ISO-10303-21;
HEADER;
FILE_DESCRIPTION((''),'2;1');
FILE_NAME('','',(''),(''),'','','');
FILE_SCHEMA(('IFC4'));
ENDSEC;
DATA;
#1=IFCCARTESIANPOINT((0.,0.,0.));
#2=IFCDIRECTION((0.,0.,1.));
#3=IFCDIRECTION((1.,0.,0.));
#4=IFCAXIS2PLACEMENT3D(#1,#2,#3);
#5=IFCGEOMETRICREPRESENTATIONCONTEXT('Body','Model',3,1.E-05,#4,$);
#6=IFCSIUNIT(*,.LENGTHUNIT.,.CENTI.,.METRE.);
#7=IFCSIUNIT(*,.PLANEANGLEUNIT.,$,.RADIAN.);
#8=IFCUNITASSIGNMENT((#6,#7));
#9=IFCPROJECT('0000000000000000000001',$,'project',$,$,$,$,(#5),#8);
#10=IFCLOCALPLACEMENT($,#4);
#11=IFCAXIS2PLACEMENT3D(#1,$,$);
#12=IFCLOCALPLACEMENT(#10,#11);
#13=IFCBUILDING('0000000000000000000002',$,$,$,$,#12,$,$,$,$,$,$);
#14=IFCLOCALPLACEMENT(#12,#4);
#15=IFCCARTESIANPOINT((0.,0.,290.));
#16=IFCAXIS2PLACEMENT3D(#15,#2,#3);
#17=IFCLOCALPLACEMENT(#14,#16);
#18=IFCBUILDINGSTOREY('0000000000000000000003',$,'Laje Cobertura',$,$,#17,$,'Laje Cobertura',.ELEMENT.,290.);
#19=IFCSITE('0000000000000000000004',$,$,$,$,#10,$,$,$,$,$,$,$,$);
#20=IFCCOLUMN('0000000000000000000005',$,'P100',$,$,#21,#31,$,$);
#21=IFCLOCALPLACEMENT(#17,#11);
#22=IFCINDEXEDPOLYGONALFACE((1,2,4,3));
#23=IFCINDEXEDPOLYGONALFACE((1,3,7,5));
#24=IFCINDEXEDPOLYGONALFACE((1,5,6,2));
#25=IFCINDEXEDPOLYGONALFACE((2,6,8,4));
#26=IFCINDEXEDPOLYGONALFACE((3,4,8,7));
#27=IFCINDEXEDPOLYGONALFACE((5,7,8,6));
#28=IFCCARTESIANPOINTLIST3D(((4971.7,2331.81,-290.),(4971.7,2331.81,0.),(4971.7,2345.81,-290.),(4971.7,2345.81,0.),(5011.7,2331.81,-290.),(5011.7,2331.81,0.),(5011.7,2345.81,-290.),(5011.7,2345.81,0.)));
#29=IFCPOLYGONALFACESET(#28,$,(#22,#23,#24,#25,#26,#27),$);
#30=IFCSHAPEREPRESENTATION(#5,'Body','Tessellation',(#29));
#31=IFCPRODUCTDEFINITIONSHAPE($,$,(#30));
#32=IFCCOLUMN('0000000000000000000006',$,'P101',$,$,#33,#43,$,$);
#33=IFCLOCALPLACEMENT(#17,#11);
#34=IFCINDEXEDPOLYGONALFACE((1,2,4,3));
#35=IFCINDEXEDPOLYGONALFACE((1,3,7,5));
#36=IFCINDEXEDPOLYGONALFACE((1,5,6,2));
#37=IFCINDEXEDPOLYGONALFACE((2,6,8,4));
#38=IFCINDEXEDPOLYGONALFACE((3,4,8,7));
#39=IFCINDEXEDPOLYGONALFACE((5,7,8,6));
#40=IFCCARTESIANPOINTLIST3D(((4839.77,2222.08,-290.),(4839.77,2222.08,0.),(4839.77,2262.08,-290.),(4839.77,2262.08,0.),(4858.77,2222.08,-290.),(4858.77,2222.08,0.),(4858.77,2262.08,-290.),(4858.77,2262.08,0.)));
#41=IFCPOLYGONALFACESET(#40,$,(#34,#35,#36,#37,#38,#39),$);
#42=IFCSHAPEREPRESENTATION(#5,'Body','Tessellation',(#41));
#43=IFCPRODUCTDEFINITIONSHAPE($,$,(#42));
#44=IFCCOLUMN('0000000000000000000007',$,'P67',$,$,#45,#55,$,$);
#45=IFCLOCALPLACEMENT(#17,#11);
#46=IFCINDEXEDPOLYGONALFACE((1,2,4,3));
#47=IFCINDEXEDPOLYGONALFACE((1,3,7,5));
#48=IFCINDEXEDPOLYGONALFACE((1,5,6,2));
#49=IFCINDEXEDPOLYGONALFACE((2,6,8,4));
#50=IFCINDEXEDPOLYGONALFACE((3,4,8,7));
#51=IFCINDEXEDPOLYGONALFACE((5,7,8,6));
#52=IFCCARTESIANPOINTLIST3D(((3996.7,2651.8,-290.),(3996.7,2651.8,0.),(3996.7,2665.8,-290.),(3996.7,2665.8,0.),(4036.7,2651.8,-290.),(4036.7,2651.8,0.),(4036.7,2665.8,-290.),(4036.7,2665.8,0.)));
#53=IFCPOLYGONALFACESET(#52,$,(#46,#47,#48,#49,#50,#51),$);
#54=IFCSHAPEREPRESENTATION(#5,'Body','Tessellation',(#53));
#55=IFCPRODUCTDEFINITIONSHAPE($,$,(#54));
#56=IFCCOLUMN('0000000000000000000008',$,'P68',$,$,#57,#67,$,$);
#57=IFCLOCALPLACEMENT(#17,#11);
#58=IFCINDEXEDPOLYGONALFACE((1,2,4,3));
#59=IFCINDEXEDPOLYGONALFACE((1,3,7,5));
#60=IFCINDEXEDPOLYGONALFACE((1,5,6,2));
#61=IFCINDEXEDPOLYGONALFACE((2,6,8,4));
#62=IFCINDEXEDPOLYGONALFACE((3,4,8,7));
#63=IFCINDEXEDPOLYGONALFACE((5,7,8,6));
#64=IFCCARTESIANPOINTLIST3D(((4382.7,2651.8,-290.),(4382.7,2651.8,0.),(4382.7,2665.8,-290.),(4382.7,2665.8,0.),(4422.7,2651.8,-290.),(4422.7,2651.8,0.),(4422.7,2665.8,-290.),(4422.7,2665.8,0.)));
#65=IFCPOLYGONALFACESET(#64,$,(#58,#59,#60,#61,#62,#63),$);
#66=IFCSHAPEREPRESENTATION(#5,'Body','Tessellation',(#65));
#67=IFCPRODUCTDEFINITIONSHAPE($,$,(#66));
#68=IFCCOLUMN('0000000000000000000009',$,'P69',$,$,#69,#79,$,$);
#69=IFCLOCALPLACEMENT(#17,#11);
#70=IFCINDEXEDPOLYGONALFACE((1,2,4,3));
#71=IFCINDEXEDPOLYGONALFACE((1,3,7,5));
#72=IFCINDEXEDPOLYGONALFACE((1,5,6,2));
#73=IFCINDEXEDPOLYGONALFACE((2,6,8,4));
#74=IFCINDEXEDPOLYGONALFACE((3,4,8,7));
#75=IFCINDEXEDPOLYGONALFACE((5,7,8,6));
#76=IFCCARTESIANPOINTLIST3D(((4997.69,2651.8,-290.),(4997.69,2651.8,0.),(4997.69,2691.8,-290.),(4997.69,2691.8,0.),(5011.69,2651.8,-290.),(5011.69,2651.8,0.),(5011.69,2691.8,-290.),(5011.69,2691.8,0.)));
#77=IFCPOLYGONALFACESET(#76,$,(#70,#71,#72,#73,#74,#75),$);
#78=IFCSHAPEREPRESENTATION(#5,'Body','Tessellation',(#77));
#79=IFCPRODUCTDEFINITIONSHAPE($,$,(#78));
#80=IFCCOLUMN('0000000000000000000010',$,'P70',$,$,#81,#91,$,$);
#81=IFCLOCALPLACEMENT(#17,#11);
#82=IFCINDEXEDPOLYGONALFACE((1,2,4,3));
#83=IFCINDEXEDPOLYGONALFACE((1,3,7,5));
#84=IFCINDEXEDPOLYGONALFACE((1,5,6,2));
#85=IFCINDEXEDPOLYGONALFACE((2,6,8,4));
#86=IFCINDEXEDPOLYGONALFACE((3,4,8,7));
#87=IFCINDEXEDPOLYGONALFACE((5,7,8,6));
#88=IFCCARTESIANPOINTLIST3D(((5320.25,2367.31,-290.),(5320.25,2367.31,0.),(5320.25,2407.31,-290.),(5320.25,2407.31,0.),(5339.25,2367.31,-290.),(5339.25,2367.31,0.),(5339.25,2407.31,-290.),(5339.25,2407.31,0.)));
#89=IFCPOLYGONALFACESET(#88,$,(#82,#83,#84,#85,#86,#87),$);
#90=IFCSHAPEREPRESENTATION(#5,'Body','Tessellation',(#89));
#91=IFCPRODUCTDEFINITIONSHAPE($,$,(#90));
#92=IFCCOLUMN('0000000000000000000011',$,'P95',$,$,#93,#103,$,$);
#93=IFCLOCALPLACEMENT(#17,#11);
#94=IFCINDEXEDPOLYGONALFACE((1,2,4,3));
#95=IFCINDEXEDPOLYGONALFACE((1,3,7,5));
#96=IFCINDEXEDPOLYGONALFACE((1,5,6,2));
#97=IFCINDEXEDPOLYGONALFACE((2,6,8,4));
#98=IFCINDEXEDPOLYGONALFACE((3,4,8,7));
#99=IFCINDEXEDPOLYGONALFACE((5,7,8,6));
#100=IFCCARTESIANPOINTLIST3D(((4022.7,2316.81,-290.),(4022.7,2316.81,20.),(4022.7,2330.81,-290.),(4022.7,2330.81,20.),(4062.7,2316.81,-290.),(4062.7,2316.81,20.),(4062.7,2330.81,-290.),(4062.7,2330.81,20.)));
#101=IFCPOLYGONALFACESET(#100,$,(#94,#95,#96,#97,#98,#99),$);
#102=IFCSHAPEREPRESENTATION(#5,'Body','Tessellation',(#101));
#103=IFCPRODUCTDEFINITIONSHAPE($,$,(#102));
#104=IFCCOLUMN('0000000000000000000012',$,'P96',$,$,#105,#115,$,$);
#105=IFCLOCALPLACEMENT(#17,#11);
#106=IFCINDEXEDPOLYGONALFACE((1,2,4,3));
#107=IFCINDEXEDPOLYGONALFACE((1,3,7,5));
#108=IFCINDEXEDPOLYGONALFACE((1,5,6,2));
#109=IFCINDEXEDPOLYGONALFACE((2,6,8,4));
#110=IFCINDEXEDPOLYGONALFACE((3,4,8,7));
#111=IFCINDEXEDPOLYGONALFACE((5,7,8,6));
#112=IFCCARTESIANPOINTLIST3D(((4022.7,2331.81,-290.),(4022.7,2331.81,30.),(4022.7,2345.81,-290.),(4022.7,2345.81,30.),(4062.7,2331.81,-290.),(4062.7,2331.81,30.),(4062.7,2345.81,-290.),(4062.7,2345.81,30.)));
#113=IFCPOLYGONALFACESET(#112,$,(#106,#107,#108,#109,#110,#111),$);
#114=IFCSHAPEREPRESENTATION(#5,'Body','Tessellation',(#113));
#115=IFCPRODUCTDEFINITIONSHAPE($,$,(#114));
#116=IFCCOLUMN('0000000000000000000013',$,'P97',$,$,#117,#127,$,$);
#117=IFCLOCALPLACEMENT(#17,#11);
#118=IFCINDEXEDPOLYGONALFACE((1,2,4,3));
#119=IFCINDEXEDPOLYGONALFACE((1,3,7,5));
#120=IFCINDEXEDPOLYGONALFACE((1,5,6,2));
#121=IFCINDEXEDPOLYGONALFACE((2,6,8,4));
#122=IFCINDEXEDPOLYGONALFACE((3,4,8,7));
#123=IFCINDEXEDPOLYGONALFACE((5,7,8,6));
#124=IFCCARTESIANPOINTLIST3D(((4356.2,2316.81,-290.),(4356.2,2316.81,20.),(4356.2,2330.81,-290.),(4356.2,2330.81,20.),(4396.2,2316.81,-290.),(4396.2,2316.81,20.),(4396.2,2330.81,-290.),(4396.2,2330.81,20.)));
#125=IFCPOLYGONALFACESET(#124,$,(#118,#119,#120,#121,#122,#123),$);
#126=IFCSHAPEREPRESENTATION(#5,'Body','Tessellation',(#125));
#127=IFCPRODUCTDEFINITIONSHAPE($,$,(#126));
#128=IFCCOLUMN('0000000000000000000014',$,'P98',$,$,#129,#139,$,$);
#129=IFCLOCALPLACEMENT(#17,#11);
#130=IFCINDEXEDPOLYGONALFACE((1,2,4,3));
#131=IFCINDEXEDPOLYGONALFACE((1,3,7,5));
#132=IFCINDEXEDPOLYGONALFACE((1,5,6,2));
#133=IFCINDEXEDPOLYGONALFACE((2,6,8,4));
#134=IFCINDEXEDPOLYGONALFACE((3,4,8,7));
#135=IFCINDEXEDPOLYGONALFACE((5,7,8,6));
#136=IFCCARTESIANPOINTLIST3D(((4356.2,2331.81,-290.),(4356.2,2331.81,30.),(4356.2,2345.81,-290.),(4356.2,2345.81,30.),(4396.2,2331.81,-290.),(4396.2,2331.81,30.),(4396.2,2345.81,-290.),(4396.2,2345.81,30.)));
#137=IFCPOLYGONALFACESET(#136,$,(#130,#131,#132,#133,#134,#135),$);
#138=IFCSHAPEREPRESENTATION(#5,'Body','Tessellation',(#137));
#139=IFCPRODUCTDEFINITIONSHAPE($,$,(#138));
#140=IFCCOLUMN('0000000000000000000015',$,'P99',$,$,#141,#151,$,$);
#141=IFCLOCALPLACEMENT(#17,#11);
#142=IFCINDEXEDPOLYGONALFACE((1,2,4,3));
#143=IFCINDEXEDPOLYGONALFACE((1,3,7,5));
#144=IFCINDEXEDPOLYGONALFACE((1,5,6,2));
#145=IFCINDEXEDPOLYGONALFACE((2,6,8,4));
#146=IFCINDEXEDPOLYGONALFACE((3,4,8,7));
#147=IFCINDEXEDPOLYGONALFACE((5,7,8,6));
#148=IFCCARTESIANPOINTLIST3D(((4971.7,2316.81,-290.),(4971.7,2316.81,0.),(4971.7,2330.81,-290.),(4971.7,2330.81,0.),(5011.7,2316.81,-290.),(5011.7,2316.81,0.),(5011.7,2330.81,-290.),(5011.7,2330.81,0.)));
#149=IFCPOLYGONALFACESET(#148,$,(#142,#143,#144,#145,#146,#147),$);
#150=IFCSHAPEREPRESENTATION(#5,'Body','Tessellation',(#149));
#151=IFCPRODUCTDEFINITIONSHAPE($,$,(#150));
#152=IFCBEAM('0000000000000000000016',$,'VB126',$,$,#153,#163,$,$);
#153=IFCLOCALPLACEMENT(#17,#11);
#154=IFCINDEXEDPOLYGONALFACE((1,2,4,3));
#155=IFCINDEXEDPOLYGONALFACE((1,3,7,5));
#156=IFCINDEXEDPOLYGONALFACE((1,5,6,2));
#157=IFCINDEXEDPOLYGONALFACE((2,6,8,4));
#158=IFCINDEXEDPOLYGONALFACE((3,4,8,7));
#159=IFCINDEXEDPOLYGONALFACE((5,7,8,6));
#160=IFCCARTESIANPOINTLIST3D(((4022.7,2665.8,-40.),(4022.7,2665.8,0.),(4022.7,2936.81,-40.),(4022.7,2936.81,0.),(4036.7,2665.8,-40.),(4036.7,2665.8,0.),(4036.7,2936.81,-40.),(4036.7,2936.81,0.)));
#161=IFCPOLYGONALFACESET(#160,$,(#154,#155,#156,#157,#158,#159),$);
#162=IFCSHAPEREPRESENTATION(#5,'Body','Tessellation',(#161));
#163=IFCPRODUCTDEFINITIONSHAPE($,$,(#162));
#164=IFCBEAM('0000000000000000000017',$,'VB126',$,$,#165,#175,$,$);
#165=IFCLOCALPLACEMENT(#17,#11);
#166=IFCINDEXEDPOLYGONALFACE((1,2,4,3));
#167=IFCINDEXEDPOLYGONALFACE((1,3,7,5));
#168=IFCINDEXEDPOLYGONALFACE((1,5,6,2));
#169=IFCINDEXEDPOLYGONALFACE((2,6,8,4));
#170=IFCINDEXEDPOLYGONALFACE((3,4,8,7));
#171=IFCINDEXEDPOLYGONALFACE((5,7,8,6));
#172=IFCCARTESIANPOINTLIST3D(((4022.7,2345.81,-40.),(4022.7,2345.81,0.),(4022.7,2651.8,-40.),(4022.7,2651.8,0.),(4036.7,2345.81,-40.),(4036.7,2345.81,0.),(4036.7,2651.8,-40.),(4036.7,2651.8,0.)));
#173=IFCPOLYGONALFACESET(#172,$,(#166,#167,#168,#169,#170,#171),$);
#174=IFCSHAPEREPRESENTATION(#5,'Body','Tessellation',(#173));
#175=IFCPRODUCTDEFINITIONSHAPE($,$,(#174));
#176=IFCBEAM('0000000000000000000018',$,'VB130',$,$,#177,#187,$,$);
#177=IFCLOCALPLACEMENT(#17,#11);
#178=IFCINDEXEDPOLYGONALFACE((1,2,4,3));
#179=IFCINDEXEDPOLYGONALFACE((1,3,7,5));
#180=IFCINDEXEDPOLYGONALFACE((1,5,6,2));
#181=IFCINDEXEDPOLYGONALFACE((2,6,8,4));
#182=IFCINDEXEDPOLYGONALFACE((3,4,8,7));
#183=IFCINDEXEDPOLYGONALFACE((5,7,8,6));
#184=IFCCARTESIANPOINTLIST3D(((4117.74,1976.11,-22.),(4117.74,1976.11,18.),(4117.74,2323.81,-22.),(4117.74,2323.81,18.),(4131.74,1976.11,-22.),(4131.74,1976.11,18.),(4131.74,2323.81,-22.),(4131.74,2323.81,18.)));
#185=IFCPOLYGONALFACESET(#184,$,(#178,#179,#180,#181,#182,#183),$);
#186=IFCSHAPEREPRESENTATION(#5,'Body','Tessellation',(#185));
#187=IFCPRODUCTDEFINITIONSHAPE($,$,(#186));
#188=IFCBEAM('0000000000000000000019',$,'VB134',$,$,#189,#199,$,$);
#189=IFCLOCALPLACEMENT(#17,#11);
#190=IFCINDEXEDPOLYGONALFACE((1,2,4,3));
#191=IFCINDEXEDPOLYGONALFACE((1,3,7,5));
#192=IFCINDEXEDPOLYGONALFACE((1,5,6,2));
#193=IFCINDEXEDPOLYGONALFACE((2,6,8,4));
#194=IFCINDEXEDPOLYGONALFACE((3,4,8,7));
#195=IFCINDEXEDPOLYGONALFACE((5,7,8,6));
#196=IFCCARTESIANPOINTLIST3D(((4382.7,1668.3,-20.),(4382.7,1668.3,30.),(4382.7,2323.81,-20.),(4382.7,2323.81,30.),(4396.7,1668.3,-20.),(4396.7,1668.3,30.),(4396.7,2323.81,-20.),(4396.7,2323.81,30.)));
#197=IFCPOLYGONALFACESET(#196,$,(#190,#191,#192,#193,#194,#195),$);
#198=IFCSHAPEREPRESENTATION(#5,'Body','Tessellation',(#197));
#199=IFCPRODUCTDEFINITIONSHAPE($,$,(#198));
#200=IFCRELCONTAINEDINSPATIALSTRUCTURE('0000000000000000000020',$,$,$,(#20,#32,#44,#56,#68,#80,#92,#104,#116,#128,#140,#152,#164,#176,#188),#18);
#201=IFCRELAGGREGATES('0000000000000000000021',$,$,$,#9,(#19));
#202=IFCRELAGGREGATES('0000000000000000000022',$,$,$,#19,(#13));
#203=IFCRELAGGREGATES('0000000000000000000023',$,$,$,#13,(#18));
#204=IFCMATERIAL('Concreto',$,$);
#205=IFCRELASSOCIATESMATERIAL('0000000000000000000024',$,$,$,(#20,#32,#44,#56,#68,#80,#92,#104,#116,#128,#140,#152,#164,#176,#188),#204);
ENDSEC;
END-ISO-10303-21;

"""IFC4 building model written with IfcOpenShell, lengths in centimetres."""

from ifc_helpers import new_model, si_unit, frame, origin, origin_with_axes, origin_2d_with_axis, place, context, project, spatial, rectangle, extrude, material, element, save


model = new_model("IFC4")

# Units and contexts
model_context = context("Model", 3, precision=1e-05, world=origin_with_axes(), identifier="Body")
ifc_project = project(units=[si_unit("LENGTHUNIT", "METRE", prefix="CENTI"), si_unit("PLANEANGLEUNIT", "RADIAN")], contexts=[model_context])

# Site, building, storey
site_placement = place(None, origin_with_axes())
site = spatial("IfcSite", under=ifc_project, at=site_placement)
building_placement = place(site_placement, origin())
building = spatial("IfcBuilding", under=site, at=building_placement)
placement = place(building_placement, origin_with_axes())
storey_placement = place(placement, frame((0.0, 0.0, 290.0), z_axis=(0.0, 0.0, 1.0), x_axis=(1.0, 0.0, 0.0)))
storey = spatial("IfcBuildingStorey", under=building, at=storey_placement, Name="Laje Cobertura", LongName="Laje Cobertura", CompositionType="ELEMENT", Elevation=290.0)

# Columns
ifc_material = material(Name="Concreto")
column_1_placement = place(storey_placement, frame((4991.7, 2338.81, 0.0), z_axis=(0.0, 0.0, 1.0), x_axis=(1.0, 0.0, 0.0)))
element("IfcColumn", 1, at=column_1_placement, inside=storey, material=ifc_material, Name="P100", context=model_context, shape_type="SolidModel", body=[
    extrude(rectangle(XDim=14.0, YDim=40.0, at=origin_2d_with_axis()), frame((0.0, 0.0, 0.0), z_axis=(0.0, 0.0, 1.0), x_axis=(0.0, -1.0, 0.0)), (0.0, 0.0, -1.0), 290.0),
])
column_2_placement = place(storey_placement, frame((4849.27, 2242.08, 0.0), z_axis=(0.0, 0.0, 1.0), x_axis=(1.0, 0.0, 0.0)))
element("IfcColumn", 2, at=column_2_placement, inside=storey, material=ifc_material, Name="P101", context=model_context, shape_type="SolidModel", body=[
    extrude(rectangle(XDim=19.0, YDim=40.0, at=origin_2d_with_axis()), origin_with_axes(), (0.0, 0.0, -1.0), 290.0),
])
for number, where, z_axis, x_axis, name in (
    (3, (4016.7, 2658.8, 0.0), (0.0, 0.0, 1.0), (1.0, 0.0, 0.0), "P67"),
    (4, (4402.7, 2658.8, 0.0), (0.0, 0.0, 1.0), (1.0, 0.0, 0.0), "P68"),
):
    element("IfcColumn", number, at=place(storey_placement, frame(where, z_axis=z_axis, x_axis=x_axis)), inside=storey, material=ifc_material, Name=name, context=model_context, shape_type="SolidModel", body=[
        extrude(rectangle(XDim=14.0, YDim=40.0, at=origin_2d_with_axis()), frame((0.0, 0.0, 0.0), z_axis=(0.0, 0.0, 1.0), x_axis=(0.0, -1.0, 0.0)), (0.0, 0.0, -1.0), 290.0),
    ])
column_3_placement = place(storey_placement, frame((5004.69, 2671.8, 0.0), z_axis=(0.0, 0.0, 1.0), x_axis=(1.0, 0.0, 0.0)))
element("IfcColumn", 5, at=column_3_placement, inside=storey, material=ifc_material, Name="P69", context=model_context, shape_type="SolidModel", body=[
    extrude(rectangle(XDim=14.0, YDim=40.0, at=origin_2d_with_axis()), origin_with_axes(), (0.0, 0.0, -1.0), 290.0),
])
column_4_placement = place(storey_placement, frame((5329.75, 2387.31, 0.0), z_axis=(0.0, 0.0, 1.0), x_axis=(1.0, 0.0, 0.0)))
element("IfcColumn", 6, at=column_4_placement, inside=storey, material=ifc_material, Name="P70", context=model_context, shape_type="SolidModel", body=[
    extrude(rectangle(XDim=19.0, YDim=40.0, at=origin_2d_with_axis()), origin_with_axes(), (0.0, 0.0, -1.0), 290.0),
])
column_5_placement = place(storey_placement, frame((4042.7, 2323.81, 20.0), z_axis=(0.0, 0.0, 1.0), x_axis=(1.0, 0.0, 0.0)))
element("IfcColumn", 7, at=column_5_placement, inside=storey, material=ifc_material, Name="P95", context=model_context, shape_type="SolidModel", body=[
    extrude(rectangle(XDim=14.0, YDim=40.0, at=origin_2d_with_axis()), frame((0.0, 0.0, 0.0), z_axis=(0.0, 0.0, 1.0), x_axis=(0.0, -1.0, 0.0)), (0.0, 0.0, -1.0), 310.0),
])
column_6_placement = place(storey_placement, frame((4042.7, 2338.81, 30.0), z_axis=(0.0, 0.0, 1.0), x_axis=(1.0, 0.0, 0.0)))
element("IfcColumn", 8, at=column_6_placement, inside=storey, material=ifc_material, Name="P96", context=model_context, shape_type="SolidModel", body=[
    extrude(rectangle(XDim=14.0, YDim=40.0, at=origin_2d_with_axis()), frame((0.0, 0.0, 0.0), z_axis=(0.0, 0.0, 1.0), x_axis=(0.0, -1.0, 0.0)), (0.0, 0.0, -1.0), 320.0),
])
column_7_placement = place(storey_placement, frame((4376.2, 2323.81, 20.0), z_axis=(0.0, 0.0, 1.0), x_axis=(1.0, 0.0, 0.0)))
element("IfcColumn", 9, at=column_7_placement, inside=storey, material=ifc_material, Name="P97", context=model_context, shape_type="SolidModel", body=[
    extrude(rectangle(XDim=14.0, YDim=40.0, at=origin_2d_with_axis()), frame((0.0, 0.0, 0.0), z_axis=(0.0, 0.0, 1.0), x_axis=(0.0, -1.0, 0.0)), (0.0, 0.0, -1.0), 310.0),
])
column_8_placement = place(storey_placement, frame((4376.2, 2338.81, 30.0), z_axis=(0.0, 0.0, 1.0), x_axis=(1.0, 0.0, 0.0)))
element("IfcColumn", 10, at=column_8_placement, inside=storey, material=ifc_material, Name="P98", context=model_context, shape_type="SolidModel", body=[
    extrude(rectangle(XDim=14.0, YDim=40.0, at=origin_2d_with_axis()), frame((0.0, 0.0, 0.0), z_axis=(0.0, 0.0, 1.0), x_axis=(0.0, -1.0, 0.0)), (0.0, 0.0, -1.0), 320.0),
])
column_9_placement = place(storey_placement, frame((4991.7, 2323.81, 0.0), z_axis=(0.0, 0.0, 1.0), x_axis=(1.0, 0.0, 0.0)))
element("IfcColumn", 11, at=column_9_placement, inside=storey, material=ifc_material, Name="P99", context=model_context, shape_type="SolidModel", body=[
    extrude(rectangle(XDim=14.0, YDim=40.0, at=origin_2d_with_axis()), frame((0.0, 0.0, 0.0), z_axis=(0.0, 0.0, 1.0), x_axis=(0.0, -1.0, 0.0)), (0.0, 0.0, -1.0), 290.0),
])

# Beams
beam_1_placement = place(storey_placement, frame((4029.7, 2801.3, 0.0), z_axis=(0.0, 0.0, 1.0), x_axis=(1.0, 0.0, 0.0)))
element("IfcBeam", 12, at=beam_1_placement, inside=storey, material=ifc_material, Name="VB126", context=model_context, shape_type="SolidModel", body=[
    extrude(rectangle(XDim=14.0, YDim=40.0, at=origin_2d_with_axis()), frame((0.0, -135.5, -20.0), z_axis=(0.0, 1.0, 0.0), x_axis=(1.0, 0.0, 0.0)), (0.0, 0.0, 1.0), 271.01),
])
beam_2_placement = place(storey_placement, frame((4029.7, 2498.8, 0.0), z_axis=(0.0, 0.0, 1.0), x_axis=(1.0, 0.0, 0.0)))
element("IfcBeam", 13, at=beam_2_placement, inside=storey, material=ifc_material, Name="VB126", context=model_context, shape_type="SolidModel", body=[
    extrude(rectangle(XDim=14.0, YDim=40.0, at=origin_2d_with_axis()), frame((0.0, -153.0, -20.0), z_axis=(0.0, 1.0, 0.0), x_axis=(1.0, 0.0, 0.0)), (0.0, 0.0, 1.0), 305.99),
])
beam_3_placement = place(storey_placement, frame((4124.74, 2149.96, 18.0), z_axis=(0.0, 0.0, 1.0), x_axis=(1.0, 0.0, 0.0)))
element("IfcBeam", 14, at=beam_3_placement, inside=storey, material=ifc_material, Name="VB130", context=model_context, shape_type="SolidModel", body=[
    extrude(rectangle(XDim=14.0, YDim=40.0, at=origin_2d_with_axis()), frame((0.0, -173.85, -20.0), z_axis=(0.0, 1.0, 0.0), x_axis=(1.0, 0.0, 0.0)), (0.0, 0.0, 1.0), 347.7),
])
for number, where, z_axis, x_axis, name in (
    (15, (4389.7, 1996.06, 30.0), (0.0, 0.0, 1.0), (1.0, 0.0, 0.0), "VB134"),
):
    element("IfcBeam", number, at=place(storey_placement, frame(where, z_axis=z_axis, x_axis=x_axis)), inside=storey, material=ifc_material, Name=name, context=model_context, shape_type="SolidModel", body=[
        extrude(rectangle(XDim=14.0, YDim=50.0, at=origin_2d_with_axis()), frame((0.0, -327.75, -25.0), z_axis=(0.0, 1.0, 0.0), x_axis=(1.0, 0.0, 0.0)), (0.0, 0.0, 1.0), 655.51),
    ])

save(model, "model.ifc")
